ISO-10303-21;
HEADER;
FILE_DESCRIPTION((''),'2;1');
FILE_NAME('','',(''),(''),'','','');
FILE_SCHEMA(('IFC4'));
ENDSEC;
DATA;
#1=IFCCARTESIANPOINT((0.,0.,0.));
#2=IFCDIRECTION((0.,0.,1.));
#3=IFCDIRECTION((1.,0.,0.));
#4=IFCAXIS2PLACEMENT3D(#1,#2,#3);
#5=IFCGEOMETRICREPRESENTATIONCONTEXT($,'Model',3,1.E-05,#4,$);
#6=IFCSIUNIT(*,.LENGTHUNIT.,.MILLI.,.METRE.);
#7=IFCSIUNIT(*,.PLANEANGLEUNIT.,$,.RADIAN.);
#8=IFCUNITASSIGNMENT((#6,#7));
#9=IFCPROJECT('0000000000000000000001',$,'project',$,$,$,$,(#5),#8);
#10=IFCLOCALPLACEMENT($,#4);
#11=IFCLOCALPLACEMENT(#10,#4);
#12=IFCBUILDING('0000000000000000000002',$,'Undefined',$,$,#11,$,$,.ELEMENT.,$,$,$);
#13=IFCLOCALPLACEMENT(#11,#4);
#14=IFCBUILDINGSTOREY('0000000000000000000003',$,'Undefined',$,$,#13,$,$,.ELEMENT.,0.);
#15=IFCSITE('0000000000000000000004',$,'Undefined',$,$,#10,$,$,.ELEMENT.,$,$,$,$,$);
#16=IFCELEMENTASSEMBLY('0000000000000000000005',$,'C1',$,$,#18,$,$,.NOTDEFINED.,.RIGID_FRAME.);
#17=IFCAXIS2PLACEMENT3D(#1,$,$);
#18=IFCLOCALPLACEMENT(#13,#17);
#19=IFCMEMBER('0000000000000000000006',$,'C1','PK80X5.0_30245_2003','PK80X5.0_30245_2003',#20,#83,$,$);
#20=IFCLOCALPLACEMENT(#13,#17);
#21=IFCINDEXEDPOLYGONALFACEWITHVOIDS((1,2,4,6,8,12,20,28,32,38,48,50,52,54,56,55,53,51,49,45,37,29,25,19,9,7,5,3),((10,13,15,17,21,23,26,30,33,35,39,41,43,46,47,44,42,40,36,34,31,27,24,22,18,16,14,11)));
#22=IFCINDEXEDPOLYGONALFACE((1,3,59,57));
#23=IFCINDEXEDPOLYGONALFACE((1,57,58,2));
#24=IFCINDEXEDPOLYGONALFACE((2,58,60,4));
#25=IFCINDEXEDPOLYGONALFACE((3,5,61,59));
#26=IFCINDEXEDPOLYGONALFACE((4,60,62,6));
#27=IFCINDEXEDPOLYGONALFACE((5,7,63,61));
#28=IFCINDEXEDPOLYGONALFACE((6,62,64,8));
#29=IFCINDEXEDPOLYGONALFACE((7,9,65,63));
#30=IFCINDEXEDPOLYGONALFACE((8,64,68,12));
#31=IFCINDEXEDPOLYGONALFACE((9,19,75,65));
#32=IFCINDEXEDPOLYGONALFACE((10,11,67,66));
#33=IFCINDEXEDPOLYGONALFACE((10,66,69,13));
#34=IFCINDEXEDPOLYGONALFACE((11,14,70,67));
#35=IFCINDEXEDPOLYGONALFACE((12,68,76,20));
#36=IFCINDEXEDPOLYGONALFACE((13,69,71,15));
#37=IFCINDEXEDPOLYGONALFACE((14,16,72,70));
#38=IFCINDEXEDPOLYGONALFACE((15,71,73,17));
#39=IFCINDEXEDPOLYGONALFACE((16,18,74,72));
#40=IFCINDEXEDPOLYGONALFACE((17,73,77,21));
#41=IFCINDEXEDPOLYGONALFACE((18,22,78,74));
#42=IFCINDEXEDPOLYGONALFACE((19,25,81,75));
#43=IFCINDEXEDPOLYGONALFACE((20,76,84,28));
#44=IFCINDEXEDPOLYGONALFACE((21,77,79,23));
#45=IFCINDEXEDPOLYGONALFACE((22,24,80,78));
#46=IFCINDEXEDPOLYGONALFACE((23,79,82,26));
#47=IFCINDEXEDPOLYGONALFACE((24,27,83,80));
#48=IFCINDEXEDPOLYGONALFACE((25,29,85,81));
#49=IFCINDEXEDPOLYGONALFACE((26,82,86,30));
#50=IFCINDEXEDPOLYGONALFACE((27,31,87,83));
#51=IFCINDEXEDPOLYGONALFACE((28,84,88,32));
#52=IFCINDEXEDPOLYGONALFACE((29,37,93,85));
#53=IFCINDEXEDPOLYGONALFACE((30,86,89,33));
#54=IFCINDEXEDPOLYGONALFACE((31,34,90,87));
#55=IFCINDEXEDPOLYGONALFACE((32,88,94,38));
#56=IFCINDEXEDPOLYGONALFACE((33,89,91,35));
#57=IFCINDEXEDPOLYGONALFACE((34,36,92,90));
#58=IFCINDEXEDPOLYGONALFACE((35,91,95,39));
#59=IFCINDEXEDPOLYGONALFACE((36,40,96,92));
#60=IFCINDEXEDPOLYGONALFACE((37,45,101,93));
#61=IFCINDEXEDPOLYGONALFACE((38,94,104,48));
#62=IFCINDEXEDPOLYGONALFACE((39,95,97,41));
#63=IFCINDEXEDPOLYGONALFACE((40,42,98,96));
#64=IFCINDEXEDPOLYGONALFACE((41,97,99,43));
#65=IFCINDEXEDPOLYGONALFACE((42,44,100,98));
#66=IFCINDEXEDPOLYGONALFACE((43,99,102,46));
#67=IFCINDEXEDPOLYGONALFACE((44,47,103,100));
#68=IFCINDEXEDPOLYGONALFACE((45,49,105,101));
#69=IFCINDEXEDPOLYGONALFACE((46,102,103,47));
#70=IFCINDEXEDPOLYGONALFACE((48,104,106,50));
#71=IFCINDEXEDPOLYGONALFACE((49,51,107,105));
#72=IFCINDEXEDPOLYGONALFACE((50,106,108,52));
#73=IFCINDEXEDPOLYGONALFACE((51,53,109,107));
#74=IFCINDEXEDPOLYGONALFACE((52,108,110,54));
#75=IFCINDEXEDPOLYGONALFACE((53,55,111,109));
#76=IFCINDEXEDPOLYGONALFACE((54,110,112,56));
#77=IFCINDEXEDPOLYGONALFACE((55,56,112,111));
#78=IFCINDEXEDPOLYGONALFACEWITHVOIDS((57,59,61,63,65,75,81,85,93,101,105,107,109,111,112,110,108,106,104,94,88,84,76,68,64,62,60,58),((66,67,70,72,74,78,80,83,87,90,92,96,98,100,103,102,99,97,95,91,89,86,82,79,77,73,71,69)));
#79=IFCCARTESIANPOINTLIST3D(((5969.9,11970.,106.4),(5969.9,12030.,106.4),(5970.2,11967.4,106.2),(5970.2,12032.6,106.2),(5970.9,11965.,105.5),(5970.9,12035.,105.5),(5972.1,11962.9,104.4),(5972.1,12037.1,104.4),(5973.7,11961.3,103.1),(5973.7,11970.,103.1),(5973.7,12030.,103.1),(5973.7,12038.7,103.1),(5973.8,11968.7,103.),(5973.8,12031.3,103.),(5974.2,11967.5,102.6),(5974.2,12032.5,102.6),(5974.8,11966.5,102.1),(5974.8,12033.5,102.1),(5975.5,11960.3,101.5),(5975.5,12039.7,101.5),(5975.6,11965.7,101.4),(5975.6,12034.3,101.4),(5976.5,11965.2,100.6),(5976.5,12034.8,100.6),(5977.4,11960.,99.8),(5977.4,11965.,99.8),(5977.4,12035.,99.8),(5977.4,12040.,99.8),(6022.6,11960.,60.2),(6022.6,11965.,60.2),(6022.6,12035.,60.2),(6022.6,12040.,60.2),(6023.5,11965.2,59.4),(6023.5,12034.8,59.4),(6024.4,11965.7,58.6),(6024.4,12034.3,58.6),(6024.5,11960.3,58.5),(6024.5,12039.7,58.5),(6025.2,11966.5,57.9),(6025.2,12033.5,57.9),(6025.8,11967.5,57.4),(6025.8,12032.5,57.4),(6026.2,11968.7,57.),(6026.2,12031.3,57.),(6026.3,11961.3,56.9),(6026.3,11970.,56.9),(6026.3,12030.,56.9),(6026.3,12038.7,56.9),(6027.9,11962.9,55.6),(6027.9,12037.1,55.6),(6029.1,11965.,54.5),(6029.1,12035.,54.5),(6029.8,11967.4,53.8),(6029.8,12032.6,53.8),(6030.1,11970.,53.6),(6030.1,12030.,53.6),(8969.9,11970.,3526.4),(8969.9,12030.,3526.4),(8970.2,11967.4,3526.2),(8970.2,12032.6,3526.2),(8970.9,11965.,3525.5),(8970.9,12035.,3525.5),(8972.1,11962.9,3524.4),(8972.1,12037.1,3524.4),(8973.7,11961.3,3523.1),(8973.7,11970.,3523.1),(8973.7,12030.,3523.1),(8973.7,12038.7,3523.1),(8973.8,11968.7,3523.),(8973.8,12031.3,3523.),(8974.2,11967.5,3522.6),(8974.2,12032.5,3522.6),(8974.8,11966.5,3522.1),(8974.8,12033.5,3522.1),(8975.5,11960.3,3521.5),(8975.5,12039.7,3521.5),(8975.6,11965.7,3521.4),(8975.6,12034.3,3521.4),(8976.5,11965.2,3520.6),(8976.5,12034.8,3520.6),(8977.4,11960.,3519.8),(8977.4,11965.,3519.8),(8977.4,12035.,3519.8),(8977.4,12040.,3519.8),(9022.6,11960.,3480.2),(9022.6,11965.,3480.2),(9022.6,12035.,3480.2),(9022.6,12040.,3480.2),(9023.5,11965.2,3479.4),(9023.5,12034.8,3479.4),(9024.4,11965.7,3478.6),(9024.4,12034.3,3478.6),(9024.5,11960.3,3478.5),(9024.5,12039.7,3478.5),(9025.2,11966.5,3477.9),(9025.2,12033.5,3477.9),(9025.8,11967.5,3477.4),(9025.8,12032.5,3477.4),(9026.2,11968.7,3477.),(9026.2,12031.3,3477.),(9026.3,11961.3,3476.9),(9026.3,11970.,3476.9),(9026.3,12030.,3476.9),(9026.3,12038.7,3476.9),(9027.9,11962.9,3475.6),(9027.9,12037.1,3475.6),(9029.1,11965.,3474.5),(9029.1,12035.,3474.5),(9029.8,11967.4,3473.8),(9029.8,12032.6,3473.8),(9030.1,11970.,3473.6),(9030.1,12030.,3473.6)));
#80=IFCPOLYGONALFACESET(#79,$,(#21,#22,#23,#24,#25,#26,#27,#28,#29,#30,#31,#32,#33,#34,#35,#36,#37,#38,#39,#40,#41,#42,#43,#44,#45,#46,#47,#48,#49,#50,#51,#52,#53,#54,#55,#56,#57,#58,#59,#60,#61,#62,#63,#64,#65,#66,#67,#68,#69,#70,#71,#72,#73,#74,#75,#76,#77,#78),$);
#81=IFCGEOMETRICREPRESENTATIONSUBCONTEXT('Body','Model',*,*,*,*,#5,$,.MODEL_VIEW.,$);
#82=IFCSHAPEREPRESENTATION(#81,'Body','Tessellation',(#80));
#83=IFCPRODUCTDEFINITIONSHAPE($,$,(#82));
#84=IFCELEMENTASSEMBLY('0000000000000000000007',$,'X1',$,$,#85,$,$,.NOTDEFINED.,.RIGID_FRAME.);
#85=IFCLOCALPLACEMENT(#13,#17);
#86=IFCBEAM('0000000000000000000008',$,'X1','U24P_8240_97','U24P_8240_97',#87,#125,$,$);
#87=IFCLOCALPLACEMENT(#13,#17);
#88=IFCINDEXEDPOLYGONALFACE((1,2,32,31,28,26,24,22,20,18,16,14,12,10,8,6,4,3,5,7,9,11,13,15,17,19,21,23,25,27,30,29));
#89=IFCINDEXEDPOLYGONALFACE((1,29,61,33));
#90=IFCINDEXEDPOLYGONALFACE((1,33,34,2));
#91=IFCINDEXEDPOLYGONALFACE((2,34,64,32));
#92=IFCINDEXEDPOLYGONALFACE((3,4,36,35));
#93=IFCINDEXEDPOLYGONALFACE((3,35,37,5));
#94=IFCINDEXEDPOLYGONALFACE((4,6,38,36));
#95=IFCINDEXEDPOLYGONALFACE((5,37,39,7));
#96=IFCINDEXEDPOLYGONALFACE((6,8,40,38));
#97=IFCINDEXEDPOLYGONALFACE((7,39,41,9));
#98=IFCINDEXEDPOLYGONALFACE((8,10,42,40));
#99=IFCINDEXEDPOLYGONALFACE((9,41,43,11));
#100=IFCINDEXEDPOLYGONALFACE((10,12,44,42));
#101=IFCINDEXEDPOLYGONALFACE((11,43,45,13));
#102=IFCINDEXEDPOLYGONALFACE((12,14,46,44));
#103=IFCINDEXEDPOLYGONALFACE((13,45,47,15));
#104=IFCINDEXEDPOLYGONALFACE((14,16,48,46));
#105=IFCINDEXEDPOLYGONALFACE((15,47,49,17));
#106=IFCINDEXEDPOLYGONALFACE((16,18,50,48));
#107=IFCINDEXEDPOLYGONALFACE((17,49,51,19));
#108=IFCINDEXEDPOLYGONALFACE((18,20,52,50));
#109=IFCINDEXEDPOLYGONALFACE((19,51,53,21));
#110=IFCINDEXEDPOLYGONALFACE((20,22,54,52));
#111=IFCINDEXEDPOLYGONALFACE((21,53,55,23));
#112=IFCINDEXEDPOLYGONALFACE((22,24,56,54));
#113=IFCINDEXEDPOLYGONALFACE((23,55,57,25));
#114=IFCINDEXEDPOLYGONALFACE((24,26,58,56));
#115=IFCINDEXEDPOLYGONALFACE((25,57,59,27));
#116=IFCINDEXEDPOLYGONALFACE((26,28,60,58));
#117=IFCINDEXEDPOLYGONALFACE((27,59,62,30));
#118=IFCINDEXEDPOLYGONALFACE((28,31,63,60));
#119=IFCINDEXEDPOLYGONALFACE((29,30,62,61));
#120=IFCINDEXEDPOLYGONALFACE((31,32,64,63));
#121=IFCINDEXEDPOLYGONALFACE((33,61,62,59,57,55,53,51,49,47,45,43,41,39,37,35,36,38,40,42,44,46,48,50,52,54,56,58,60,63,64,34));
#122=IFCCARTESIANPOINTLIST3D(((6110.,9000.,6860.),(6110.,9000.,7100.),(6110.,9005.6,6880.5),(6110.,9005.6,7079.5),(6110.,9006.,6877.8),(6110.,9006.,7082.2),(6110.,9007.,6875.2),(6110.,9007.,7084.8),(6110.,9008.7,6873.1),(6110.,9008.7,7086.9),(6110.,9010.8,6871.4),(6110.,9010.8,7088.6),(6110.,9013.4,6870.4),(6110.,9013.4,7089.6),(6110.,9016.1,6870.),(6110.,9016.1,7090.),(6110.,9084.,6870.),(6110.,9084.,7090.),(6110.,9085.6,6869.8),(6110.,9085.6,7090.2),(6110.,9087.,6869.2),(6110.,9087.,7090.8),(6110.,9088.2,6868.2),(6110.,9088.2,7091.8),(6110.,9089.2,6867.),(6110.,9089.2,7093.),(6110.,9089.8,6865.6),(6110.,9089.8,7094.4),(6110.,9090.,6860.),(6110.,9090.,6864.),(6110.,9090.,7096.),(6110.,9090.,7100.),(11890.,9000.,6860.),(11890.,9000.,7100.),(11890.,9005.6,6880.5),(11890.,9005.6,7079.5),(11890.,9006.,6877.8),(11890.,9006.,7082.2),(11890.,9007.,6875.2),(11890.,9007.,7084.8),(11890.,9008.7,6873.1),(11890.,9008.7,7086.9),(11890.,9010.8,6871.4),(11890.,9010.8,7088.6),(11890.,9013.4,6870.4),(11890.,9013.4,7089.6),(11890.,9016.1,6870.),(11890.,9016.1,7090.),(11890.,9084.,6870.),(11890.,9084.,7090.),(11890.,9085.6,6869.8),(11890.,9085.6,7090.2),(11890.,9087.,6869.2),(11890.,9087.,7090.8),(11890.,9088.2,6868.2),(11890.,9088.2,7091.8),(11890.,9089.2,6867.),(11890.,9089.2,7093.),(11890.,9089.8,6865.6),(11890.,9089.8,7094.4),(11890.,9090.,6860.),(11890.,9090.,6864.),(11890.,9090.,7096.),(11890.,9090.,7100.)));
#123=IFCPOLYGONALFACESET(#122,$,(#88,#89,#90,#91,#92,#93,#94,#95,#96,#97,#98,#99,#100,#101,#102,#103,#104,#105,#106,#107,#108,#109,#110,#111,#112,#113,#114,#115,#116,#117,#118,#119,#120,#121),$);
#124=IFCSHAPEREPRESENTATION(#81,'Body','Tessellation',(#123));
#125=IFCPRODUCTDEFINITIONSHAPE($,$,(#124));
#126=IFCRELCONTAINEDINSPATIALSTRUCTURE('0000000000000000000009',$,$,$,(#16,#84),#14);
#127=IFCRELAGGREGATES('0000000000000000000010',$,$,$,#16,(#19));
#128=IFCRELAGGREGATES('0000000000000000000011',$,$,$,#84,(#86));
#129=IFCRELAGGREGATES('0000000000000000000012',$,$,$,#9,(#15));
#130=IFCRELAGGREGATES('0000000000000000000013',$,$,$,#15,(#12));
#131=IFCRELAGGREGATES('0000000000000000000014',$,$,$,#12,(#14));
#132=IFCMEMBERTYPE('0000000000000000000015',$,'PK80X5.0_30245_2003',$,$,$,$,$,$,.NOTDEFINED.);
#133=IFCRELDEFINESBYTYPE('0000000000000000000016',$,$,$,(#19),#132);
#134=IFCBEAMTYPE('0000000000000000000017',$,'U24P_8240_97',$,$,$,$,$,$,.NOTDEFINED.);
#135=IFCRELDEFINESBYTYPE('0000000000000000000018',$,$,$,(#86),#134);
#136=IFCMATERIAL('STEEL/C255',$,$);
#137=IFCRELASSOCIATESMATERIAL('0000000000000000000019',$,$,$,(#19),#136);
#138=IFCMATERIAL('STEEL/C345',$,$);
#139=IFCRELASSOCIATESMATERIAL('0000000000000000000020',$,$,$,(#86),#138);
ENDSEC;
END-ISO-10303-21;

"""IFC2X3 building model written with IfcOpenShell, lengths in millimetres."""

from ifc_helpers import new_model, si_unit, frame, origin_with_axes, origin_2d_with_axis, place, context, subcontext, project, spatial, hollow_rectangle, u_section, extrude, material, type_object, element, aggregate, save


model = new_model("IFC2X3")

# Units and contexts
model_context = context("Model", 3, precision=1e-05, world=origin_with_axes())
body_context = subcontext(model_context, "Body", "Model", "MODEL_VIEW")
ifc_project = project(units=[si_unit("LENGTHUNIT", "METRE", prefix="MILLI"), si_unit("PLANEANGLEUNIT", "RADIAN")], contexts=[model_context])

# Site, building, storey
site_placement = place(None, origin_with_axes())
site = spatial("IfcSite", under=ifc_project, at=site_placement, Name="Undefined", CompositionType="ELEMENT")
building_placement = place(site_placement, origin_with_axes())
building = spatial("IfcBuilding", under=site, at=building_placement, Name="Undefined", CompositionType="ELEMENT")
storey_placement = place(building_placement, origin_with_axes())
storey = spatial("IfcBuildingStorey", under=building, at=storey_placement, Name="Undefined", CompositionType="ELEMENT", Elevation=0.0)

# Shared definitions
ifc_material_1 = material(Name="STEEL/C345")

# Shared definitions
ifc_material_2 = material(Name="STEEL/C255")

# Element assembly, member
member_type = type_object("IfcMemberType", Name="PK80X5.0_30245_2003", PredefinedType="NOTDEFINED")
assembly_1_placement = place(storey_placement, origin_with_axes())
assembly_1 = element("IfcElementAssembly", 1, at=assembly_1_placement, inside=storey, Name="C1", AssemblyPlace="NOTDEFINED", PredefinedType="RIGID_FRAME")
member_1_placement = place(assembly_1_placement, frame((6000.0, 12000.0, 80.0), z_axis=(0.751759, 0.0, -0.659438), x_axis=(0.659438, 0.0, 0.751759)))
member_1 = element("IfcMember", 2, at=member_1_placement, type_object=member_type, material=ifc_material_2, Name="C1", Description="PK80X5.0_30245_2003", ObjectType="PK80X5.0_30245_2003", context=body_context, shape_type="SweptSolid", body=[
    extrude(hollow_rectangle(XDim=80.0, YDim=80.0, WallThickness=5.0, InnerFilletRadius=5.0, OuterFilletRadius=10.0, at=origin_2d_with_axis()), frame((4549.3, 0.0, 0.0), z_axis=(-1.0, 0.0, 0.0), x_axis=(0.0, -1.0, 0.0)), (0.0, 0.0, 1.0), 4549.3),
])
aggregate(assembly_1, [member_1])

# Element assembly, beam
assembly_2_placement = place(storey_placement, origin_with_axes())
assembly_2 = element("IfcElementAssembly", 3, at=assembly_2_placement, inside=storey, Name="X1", AssemblyPlace="NOTDEFINED", PredefinedType="RIGID_FRAME")
beam_type_1 = type_object("IfcBeamType", Name="U24P_8240_97", PredefinedType="NOTDEFINED")
beam_1_placement = place(assembly_2_placement, frame((6110.0, 9045.0, 6980.0), z_axis=(0.0, 0.0, -1.0), x_axis=(1.0, 0.0, 0.0)))
beam_1 = element("IfcBeam", 4, at=beam_1_placement, type_object=beam_type_1, material=ifc_material_1, Name="X1", Description="U24P_8240_97", ObjectType="U24P_8240_97", context=body_context, shape_type="SweptSolid", body=[
    extrude(u_section(Depth=240.0, FlangeWidth=90.0, WebThickness=5.6, FlangeThickness=10.0, FilletRadius=10.5, EdgeRadius=6.0, at=origin_2d_with_axis()), frame((5780.0, 0.0, 0.0), z_axis=(-1.0, 0.0, 0.0), x_axis=(0.0, -1.0, 0.0)), (0.0, 0.0, 1.0), 5780.0),
])
aggregate(assembly_2, [beam_1])

save(model, "model.ifc")
